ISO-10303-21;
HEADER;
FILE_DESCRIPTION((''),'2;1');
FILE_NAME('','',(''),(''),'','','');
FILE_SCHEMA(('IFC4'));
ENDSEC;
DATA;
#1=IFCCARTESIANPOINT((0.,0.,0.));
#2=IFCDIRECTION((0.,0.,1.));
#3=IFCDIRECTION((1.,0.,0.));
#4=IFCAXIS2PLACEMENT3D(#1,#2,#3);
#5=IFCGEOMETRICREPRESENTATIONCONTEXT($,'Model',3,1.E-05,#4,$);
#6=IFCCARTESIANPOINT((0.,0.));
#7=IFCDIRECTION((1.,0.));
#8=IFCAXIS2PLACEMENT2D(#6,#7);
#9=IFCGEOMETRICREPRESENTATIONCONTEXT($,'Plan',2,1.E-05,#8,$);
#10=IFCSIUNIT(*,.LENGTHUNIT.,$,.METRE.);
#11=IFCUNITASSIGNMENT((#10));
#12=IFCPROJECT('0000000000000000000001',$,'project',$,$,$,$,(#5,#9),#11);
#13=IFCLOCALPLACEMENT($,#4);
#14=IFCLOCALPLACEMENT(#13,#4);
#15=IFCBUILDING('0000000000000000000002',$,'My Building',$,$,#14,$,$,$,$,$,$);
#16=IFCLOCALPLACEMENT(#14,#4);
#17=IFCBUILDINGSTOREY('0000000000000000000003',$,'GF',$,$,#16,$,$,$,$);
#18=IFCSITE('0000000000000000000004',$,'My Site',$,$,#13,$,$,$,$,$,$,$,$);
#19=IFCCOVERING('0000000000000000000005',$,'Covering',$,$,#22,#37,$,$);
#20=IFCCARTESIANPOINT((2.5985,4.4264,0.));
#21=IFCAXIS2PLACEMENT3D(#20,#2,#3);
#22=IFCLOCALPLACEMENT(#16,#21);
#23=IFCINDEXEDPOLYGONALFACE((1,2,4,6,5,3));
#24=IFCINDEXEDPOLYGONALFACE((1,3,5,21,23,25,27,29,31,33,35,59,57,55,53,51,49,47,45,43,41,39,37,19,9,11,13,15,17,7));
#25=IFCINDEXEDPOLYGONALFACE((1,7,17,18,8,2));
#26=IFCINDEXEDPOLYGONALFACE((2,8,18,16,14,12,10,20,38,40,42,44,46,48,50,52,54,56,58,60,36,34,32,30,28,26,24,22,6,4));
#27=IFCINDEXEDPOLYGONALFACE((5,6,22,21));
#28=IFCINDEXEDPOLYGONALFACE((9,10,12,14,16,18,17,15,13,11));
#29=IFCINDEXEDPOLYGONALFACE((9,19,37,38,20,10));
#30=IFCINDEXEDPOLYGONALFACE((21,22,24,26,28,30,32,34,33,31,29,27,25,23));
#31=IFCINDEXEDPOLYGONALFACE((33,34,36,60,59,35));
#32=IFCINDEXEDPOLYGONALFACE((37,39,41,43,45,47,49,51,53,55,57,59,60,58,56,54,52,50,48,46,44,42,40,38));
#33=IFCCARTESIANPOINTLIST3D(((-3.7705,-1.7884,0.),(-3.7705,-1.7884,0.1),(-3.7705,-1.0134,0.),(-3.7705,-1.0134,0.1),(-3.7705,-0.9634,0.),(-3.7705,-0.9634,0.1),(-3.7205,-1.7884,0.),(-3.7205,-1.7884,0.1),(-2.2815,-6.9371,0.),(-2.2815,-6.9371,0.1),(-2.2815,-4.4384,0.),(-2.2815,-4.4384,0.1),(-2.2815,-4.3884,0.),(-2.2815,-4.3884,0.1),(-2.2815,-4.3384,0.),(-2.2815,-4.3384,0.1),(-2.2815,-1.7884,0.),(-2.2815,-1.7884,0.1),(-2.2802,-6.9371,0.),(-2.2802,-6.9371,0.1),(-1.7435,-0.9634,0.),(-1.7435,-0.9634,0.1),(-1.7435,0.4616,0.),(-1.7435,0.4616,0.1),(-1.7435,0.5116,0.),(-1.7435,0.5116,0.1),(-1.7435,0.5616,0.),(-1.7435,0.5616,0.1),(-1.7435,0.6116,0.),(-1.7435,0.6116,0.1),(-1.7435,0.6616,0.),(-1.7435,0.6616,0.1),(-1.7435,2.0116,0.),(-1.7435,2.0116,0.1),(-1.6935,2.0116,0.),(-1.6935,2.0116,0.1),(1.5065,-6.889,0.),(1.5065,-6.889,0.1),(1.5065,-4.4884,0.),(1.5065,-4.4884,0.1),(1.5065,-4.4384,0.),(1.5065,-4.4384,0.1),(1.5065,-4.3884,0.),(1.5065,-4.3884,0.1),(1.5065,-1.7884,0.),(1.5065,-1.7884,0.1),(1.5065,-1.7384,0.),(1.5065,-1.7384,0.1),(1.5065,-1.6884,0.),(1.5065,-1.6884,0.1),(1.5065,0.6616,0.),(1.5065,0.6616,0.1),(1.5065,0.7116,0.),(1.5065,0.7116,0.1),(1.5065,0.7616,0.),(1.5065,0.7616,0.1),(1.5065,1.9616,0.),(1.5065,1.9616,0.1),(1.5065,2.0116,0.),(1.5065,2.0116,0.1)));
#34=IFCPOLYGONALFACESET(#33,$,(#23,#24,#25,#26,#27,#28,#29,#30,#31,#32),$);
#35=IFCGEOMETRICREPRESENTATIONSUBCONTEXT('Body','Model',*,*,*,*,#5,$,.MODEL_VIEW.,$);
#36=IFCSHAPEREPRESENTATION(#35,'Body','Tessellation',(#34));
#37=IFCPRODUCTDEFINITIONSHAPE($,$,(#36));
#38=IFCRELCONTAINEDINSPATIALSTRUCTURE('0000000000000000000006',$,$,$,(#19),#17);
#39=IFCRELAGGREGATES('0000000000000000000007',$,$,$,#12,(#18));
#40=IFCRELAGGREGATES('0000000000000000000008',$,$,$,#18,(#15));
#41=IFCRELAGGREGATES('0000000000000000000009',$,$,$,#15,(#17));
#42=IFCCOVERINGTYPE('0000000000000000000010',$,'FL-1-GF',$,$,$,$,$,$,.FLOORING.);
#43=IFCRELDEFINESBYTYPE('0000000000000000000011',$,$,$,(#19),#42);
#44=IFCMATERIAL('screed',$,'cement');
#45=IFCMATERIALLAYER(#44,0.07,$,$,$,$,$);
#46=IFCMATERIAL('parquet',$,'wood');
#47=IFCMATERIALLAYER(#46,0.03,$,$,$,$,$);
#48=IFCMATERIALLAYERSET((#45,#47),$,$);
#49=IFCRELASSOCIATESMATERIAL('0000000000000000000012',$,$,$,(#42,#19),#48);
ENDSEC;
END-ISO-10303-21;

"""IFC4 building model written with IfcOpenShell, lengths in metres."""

from ifc_helpers import new_model, si_unit, frame, origin_with_axes, origin_2d_with_axis, place, context, subcontext, project, spatial, line, indexed_curve, outline, extrude, material, layer, layer_set, layer_usage, type_object, element, save


model = new_model("IFC4")

# Units and contexts
model_context = context("Model", 3, precision=1e-05, world=origin_with_axes())
plan_context = context("Plan", 2, precision=1e-05, world=origin_2d_with_axis())
body_context_1 = subcontext(model_context, "Body", "Model", "MODEL_VIEW")
ifc_project = project(units=[si_unit("LENGTHUNIT", "METRE")], contexts=[model_context, plan_context])

# Site, building, storey
site_placement = place(None, origin_with_axes())
site = spatial("IfcSite", under=ifc_project, at=site_placement, Name="My Site")
building_placement = place(site_placement, origin_with_axes())
building = spatial("IfcBuilding", under=site, at=building_placement, Name="My Building")
storey_placement = place(building_placement, origin_with_axes())
storey = spatial("IfcBuildingStorey", under=building, at=storey_placement, Name="GF")

# Covering
ifc_material_1 = material(Name="screed", Category="cement")
ifc_layer_1 = layer(ifc_material_1, 0.07)
ifc_material_2 = material(Name="parquet", Category="wood")
ifc_layer_2 = layer(ifc_material_2, 0.03)
ifc_layer_set_1 = layer_set([ifc_layer_1, ifc_layer_2])
ifc_layer_usage_1 = layer_usage(ifc_layer_set_1, "AXIS3", "POSITIVE", 0.0)
covering_type = type_object("IfcCoveringType", Name="FL-1-GF", PredefinedType="FLOORING", material=ifc_layer_set_1)
covering_1_placement = place(storey_placement, frame((2.5985, 4.4264, 0.0), z_axis=(0.0, 0.0, 1.0), x_axis=(1.0, 0.0, 0.0)))
element("IfcCovering", 1, at=covering_1_placement, inside=storey, type_object=covering_type, material=ifc_layer_usage_1, Name="Covering", context=body_context_1, shape_type="SweptSolid", body=[
    extrude(outline(indexed_curve([(-1.7435, 2.0116), (-1.6935, 2.0116), (1.5065, 2.0116), (1.5065, 1.9616), (1.5065, 0.7616), (1.5065, 0.7116), (1.5065, 0.6616), (1.5065, -1.6884), (1.5065, -1.7384), (1.5065, -1.7884), (1.5065, -4.3884), (1.5065, -4.4384), (1.5065, -4.4884), (1.5065, -6.889), (-2.2802, -6.9371), (-2.2815, -6.9371), (-2.2815, -4.4384), (-2.2815, -4.3884), (-2.2815, -4.3384), (-2.2815, -1.7884), (-3.7205, -1.7884), (-3.7705, -1.7884), (-3.7705, -1.0134), (-3.7705, -0.9634), (-1.7435, -0.9634), (-1.7435, 0.4616), (-1.7435, 0.5116), (-1.7435, 0.5616), (-1.7435, 0.6116), (-1.7435, 0.6616)], segments=[line(1, 2, 3, 4, 5, 6, 7, 8, 9, 10, 11, 12, 13, 14, 15, 16, 17, 18, 19, 20, 21, 22, 23, 24, 25, 26, 27, 28, 29, 30, 1)])), origin_with_axes(), (0.0, 0.0, 1.0), 0.1),
])

save(model, "model.ifc")
